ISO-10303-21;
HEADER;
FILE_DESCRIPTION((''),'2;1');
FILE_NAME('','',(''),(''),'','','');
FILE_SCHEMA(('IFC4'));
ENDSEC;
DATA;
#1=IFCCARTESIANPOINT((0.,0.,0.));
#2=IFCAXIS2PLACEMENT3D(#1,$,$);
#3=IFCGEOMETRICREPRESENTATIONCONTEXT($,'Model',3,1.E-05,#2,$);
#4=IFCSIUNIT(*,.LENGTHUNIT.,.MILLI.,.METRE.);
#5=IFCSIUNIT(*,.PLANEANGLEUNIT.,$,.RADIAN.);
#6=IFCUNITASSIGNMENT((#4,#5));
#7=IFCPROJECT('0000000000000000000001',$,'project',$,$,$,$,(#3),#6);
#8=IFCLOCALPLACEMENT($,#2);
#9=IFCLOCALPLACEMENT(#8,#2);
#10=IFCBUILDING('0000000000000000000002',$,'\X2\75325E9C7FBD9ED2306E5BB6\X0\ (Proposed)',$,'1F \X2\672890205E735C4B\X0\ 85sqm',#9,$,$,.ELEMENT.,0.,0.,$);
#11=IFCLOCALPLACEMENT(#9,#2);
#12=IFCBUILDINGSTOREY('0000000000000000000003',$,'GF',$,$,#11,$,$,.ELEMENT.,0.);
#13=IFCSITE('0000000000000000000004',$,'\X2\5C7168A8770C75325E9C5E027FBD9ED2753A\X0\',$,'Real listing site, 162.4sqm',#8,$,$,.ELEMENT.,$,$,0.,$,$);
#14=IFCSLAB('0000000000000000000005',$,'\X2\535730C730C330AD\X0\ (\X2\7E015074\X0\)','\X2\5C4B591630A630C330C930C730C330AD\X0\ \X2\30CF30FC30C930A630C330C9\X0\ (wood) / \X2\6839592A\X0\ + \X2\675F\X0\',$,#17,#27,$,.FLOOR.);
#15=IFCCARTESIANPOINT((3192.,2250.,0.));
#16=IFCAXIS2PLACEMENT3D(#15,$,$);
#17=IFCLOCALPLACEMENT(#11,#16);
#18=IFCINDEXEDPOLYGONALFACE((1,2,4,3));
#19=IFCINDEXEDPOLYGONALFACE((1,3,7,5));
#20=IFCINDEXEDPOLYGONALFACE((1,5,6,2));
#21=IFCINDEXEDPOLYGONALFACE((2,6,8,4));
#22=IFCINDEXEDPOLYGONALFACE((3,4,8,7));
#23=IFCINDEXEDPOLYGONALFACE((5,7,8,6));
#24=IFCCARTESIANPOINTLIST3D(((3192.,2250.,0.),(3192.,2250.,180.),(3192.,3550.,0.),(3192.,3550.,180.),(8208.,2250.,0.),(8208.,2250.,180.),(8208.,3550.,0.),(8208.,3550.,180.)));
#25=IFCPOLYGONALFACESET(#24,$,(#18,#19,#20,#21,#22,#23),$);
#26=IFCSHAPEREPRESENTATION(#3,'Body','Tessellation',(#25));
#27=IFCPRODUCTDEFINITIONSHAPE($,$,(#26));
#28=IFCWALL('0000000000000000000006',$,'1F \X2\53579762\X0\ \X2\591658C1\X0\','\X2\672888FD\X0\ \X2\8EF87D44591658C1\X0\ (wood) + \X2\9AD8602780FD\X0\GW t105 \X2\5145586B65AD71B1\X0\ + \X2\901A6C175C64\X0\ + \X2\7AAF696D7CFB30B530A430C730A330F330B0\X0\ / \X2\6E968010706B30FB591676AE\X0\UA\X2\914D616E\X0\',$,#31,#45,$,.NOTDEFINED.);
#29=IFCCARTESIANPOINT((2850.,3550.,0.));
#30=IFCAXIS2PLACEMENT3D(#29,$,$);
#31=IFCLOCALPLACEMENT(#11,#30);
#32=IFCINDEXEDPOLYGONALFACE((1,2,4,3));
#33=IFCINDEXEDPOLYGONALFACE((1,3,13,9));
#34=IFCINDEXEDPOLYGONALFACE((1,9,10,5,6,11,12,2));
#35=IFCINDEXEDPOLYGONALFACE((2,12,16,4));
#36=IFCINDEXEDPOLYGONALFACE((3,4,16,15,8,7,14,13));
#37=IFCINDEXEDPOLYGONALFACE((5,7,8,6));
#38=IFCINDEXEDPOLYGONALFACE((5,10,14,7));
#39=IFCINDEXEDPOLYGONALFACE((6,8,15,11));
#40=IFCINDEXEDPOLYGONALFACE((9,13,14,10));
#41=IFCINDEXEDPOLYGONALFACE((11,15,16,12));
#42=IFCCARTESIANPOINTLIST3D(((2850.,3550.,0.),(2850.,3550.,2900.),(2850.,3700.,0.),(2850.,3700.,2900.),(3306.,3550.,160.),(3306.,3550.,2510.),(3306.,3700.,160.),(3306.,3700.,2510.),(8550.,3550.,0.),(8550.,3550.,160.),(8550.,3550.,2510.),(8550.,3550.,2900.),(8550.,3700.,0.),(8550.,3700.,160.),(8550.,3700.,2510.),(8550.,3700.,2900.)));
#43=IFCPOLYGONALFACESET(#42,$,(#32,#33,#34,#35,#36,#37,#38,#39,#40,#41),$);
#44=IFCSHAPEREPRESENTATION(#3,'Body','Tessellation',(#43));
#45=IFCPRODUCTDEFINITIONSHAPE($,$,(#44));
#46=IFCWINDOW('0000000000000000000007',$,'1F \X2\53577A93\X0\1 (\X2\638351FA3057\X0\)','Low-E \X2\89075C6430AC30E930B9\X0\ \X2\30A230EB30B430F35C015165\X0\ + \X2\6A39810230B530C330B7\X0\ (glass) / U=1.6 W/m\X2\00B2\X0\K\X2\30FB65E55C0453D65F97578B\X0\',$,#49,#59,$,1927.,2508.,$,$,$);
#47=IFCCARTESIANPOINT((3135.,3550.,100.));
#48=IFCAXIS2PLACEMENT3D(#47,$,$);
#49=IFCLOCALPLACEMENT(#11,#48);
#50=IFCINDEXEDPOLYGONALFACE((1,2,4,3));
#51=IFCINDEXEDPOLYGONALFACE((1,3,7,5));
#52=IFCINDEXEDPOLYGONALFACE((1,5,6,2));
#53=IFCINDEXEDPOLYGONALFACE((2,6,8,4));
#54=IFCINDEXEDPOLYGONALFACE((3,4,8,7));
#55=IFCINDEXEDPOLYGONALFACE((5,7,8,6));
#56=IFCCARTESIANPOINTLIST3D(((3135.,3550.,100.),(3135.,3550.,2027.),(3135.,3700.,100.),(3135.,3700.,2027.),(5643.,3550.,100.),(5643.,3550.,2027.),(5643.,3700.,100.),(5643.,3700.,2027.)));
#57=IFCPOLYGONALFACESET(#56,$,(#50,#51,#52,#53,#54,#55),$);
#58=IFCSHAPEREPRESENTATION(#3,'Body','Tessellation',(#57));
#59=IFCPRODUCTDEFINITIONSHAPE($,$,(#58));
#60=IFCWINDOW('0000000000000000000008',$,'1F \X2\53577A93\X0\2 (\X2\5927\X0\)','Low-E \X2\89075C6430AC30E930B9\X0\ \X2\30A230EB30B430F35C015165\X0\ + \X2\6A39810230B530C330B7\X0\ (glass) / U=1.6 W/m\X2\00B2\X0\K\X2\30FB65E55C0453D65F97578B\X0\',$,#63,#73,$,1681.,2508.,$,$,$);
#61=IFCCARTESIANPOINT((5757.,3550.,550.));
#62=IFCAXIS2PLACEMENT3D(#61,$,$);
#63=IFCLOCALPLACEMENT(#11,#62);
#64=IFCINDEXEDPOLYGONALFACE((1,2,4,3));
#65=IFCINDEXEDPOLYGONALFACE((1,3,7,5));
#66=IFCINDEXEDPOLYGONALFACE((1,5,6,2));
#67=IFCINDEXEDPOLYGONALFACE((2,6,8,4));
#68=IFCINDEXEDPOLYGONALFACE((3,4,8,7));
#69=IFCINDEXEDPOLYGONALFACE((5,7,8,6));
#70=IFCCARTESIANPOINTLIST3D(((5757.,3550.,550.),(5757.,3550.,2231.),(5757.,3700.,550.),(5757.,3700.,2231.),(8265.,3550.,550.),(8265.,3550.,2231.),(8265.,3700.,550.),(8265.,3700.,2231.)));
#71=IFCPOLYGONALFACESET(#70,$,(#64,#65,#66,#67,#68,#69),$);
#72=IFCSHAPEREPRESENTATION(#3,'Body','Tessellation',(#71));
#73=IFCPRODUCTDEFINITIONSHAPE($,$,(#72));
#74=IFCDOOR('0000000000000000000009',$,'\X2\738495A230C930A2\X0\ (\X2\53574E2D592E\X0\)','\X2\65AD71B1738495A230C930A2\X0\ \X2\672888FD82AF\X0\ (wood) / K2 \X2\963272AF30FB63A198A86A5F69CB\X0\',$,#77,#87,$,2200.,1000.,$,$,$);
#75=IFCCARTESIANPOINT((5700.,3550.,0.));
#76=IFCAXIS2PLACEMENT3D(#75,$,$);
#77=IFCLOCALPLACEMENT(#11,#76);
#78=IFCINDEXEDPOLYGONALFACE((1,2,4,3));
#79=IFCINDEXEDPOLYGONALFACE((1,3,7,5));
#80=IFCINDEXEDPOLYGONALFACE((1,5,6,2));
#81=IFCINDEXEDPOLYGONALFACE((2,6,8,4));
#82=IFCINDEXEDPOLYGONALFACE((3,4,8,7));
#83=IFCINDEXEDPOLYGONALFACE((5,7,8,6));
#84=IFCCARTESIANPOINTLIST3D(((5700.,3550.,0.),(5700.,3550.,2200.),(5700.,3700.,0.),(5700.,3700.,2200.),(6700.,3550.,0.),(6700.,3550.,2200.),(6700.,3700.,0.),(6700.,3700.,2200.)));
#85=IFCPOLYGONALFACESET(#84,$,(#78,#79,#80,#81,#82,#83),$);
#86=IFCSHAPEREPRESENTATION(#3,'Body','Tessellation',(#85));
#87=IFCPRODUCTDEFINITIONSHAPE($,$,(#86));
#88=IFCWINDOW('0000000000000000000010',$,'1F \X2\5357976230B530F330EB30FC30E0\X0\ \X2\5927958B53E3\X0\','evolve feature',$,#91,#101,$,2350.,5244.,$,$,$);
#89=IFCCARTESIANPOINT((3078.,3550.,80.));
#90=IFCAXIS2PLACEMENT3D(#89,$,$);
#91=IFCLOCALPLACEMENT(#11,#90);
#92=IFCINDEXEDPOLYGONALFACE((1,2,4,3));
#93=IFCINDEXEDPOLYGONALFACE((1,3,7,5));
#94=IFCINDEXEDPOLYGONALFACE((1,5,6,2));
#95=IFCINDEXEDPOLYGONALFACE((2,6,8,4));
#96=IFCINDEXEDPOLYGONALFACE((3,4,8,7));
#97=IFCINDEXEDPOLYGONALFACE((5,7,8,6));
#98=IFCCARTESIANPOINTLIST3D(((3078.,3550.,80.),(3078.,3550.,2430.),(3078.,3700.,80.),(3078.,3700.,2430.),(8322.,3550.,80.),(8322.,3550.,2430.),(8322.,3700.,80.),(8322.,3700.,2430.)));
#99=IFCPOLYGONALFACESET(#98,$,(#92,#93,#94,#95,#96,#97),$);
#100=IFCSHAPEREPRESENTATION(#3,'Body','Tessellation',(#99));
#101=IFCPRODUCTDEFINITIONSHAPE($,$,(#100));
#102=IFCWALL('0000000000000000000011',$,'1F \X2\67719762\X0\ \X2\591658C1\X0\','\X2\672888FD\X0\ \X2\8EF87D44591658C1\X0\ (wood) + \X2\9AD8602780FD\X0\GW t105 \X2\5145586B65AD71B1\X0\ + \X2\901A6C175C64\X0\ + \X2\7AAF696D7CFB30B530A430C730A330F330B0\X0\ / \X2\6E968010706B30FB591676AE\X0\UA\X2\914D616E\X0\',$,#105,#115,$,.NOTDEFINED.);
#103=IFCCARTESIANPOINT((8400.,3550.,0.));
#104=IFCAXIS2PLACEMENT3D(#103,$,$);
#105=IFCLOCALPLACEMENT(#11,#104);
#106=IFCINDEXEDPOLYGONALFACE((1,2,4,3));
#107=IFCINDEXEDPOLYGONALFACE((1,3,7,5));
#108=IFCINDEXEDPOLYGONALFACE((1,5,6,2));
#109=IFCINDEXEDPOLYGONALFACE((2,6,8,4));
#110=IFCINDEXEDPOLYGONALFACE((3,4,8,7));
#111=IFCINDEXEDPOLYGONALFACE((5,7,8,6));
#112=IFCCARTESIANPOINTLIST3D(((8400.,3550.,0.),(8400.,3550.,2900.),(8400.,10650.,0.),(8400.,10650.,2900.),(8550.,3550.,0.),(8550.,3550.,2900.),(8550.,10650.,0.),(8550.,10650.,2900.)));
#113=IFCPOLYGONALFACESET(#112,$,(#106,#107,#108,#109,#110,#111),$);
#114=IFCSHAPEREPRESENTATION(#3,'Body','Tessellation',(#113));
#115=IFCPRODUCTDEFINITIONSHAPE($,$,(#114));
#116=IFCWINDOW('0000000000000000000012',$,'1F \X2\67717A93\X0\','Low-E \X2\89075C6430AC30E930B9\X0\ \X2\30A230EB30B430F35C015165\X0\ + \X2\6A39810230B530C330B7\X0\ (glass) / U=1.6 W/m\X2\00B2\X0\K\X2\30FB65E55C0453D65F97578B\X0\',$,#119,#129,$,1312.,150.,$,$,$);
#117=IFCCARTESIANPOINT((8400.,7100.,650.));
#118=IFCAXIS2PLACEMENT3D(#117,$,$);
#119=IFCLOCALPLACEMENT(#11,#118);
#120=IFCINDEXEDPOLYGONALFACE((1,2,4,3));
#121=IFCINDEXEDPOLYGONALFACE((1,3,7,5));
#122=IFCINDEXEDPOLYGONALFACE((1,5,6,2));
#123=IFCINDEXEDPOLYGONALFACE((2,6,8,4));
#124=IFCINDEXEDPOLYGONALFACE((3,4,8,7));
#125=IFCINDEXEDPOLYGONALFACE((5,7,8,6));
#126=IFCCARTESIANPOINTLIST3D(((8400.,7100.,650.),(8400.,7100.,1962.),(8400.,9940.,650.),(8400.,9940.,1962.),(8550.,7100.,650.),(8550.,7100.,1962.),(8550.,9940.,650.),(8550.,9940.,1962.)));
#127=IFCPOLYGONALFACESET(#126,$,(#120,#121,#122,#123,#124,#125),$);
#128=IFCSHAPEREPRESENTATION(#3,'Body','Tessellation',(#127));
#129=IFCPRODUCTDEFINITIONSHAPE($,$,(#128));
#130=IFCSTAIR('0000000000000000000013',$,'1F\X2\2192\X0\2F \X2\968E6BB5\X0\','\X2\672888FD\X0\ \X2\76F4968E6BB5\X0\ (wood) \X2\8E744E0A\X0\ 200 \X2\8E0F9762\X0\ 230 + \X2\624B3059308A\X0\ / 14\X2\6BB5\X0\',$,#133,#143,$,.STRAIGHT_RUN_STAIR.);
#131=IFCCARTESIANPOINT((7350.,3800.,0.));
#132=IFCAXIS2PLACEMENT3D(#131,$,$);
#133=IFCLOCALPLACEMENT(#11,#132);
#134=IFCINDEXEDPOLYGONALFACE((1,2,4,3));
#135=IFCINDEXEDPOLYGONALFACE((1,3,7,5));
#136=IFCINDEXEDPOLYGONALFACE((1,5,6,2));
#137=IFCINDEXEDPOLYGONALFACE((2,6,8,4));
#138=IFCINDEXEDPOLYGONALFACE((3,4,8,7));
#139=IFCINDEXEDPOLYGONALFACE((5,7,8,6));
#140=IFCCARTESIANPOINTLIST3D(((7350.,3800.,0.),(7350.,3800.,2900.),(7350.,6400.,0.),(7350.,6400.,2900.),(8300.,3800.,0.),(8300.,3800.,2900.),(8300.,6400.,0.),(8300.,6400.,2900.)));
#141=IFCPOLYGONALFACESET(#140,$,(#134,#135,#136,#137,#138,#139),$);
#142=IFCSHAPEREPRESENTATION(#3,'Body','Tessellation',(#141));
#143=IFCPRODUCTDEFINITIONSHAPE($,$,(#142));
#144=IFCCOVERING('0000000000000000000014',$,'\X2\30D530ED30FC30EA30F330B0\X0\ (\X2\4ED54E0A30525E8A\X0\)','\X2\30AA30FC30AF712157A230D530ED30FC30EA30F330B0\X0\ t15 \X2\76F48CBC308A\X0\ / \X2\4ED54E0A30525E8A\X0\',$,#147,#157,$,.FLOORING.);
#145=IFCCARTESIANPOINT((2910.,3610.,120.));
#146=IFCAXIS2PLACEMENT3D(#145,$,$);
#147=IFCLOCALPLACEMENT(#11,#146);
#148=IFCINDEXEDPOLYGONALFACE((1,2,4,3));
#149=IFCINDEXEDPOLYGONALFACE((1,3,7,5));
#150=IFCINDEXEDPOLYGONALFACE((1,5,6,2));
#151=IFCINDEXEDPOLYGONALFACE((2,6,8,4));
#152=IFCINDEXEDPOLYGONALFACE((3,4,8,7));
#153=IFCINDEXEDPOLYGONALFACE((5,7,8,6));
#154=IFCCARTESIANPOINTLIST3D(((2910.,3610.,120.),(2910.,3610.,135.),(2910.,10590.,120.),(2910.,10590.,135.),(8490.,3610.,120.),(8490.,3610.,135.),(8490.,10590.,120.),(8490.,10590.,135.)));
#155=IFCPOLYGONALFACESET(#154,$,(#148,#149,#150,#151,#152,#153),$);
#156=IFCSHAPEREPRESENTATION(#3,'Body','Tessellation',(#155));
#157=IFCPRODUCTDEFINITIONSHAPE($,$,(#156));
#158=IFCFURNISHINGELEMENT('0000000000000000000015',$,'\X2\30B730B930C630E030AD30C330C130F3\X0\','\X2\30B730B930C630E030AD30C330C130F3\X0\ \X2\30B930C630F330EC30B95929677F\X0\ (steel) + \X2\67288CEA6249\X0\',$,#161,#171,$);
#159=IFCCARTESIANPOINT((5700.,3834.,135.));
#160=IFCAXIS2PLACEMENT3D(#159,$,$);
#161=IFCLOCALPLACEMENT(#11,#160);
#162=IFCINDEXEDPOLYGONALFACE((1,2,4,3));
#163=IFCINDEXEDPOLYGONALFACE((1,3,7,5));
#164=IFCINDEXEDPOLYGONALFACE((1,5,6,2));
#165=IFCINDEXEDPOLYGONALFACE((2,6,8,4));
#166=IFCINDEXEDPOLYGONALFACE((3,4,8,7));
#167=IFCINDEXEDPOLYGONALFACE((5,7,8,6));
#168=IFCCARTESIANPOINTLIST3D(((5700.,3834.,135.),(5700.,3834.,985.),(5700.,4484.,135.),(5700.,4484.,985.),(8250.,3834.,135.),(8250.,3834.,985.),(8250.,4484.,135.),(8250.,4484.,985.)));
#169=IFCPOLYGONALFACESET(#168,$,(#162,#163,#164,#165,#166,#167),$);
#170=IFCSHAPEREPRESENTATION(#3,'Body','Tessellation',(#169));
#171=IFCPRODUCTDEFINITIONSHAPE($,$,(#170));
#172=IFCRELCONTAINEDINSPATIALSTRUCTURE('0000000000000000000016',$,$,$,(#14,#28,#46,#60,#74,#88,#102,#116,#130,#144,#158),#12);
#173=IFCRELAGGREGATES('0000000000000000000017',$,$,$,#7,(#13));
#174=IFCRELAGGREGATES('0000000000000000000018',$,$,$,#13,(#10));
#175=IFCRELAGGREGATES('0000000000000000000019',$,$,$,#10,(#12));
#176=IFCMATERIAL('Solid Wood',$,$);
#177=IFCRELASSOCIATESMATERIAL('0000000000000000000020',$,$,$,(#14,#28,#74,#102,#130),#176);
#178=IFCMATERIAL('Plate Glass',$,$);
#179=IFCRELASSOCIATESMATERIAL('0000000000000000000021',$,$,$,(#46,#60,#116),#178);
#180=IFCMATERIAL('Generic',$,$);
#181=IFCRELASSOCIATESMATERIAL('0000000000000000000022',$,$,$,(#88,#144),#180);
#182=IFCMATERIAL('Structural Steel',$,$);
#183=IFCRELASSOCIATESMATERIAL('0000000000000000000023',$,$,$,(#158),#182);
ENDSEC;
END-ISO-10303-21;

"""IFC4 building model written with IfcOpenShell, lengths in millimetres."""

from ifc_helpers import new_model, si_unit, frame, frame_2d, origin, place, context, project, spatial, rectangle, extrude, material, element, fill, save


model = new_model("IFC4")

# Units and contexts
model_context = context("Model", 3, precision=1e-05, world=origin())
ifc_project = project(units=[si_unit("LENGTHUNIT", "METRE", prefix="MILLI"), si_unit("PLANEANGLEUNIT", "RADIAN")], contexts=[model_context])

# Site, building, storey
site_placement = place(None, origin())
site = spatial("IfcSite", under=ifc_project, at=site_placement, Name="山梨県甲府市羽黒町", ObjectType="Real listing site, 162.4sqm", CompositionType="ELEMENT", RefElevation=0.0)
building_placement = place(site_placement, origin())
building = spatial("IfcBuilding", under=site, at=building_placement, Name="甲府羽黒の家 (Proposed)", ObjectType="1F 木造平屋 85sqm", CompositionType="ELEMENT", ElevationOfRefHeight=0.0, ElevationOfTerrain=0.0)
storey_placement = place(building_placement, origin())
storey = spatial("IfcBuildingStorey", under=building, at=storey_placement, Name="GF", CompositionType="ELEMENT", Elevation=0.0)

# Slab
ifc_material_1 = material(Name="Solid Wood")
slab_1_placement = place(storey_placement, frame((3192.0, 2250.0, 0.0)))
element("IfcSlab", 1, at=slab_1_placement, inside=storey, material=ifc_material_1, Name="南デッキ (縁側)", Description="屋外ウッドデッキ ハードウッド (wood) / 根太 + 束", PredefinedType="FLOOR", context=model_context, shape_type="SweptSolid", body=[
    extrude(rectangle(XDim=5016.0, YDim=1300.0, at=frame_2d((2508.0, 650.0))), frame((3192.0, 2250.0, 0.0)), (0.0, 0.0, 1.0), 180.0),
])
ifc_material_2 = material(Name="Generic")

# Wall, openings, windows, door
wall_1_placement = place(storey_placement, frame((2850.0, 3550.0, 0.0)))
wall_1 = element("IfcWall", 2, at=wall_1_placement, inside=storey, material=ifc_material_1, Name="1F 南面 外壁", Description="木製 軸組外壁 (wood) + 高性能GW t105 充填断熱 + 通気層 + 窯業系サイディング / 準耐火・外皮UA配慮", PredefinedType="NOTDEFINED", context=model_context, shape_type="SweptSolid", body=[
    extrude(rectangle(XDim=5700.0, YDim=150.0, at=frame_2d((2850.0, 75.0))), frame((2850.0, 3550.0, 0.0)), (0.0, 0.0, 1.0), 2900.0),
])
opening_1_placement = place(storey_placement, frame((3135.0, 3550.0, 100.0)))
opening_1 = element("IfcOpeningElement", 3, at=opening_1_placement, cuts=wall_1, PredefinedType="NOTDEFINED", context=model_context, shape_type="SweptSolid", body=[
    extrude(rectangle(XDim=2508.0, YDim=150.0, at=frame_2d((1254.0, 75.0))), frame((3135.0, 3550.0, 100.0)), (0.0, 0.0, 1.0), 1927.0),
])
opening_2_placement = place(storey_placement, frame((5757.0, 3550.0, 550.0)))
opening_2 = element("IfcOpeningElement", 4, at=opening_2_placement, cuts=wall_1, PredefinedType="NOTDEFINED", context=model_context, shape_type="SweptSolid", body=[
    extrude(rectangle(XDim=2508.0, YDim=150.0, at=frame_2d((1254.0, 75.0))), frame((5757.0, 3550.0, 550.0)), (0.0, 0.0, 1.0), 1681.0),
])
opening_3_placement = place(storey_placement, frame((5700.0, 3550.0, 0.0)))
opening_3 = element("IfcOpeningElement", 5, at=opening_3_placement, cuts=wall_1, PredefinedType="NOTDEFINED", context=model_context, shape_type="SweptSolid", body=[
    extrude(rectangle(XDim=1000.0, YDim=150.0, at=frame_2d((500.0, 75.0))), frame((5700.0, 3550.0, 0.0)), (0.0, 0.0, 1.0), 2200.0),
])
opening_4_placement = place(storey_placement, frame((3078.0, 3550.0, 80.0)))
opening_4 = element("IfcOpeningElement", 6, at=opening_4_placement, cuts=wall_1, PredefinedType="NOTDEFINED", context=model_context, shape_type="SweptSolid", body=[
    extrude(rectangle(XDim=5244.0, YDim=150.0, at=frame_2d((2622.0, 75.0))), frame((3078.0, 3550.0, 80.0)), (0.0, 0.0, 1.0), 2350.0),
])
ifc_material_3 = material(Name="Plate Glass")
window_1_placement = place(storey_placement, frame((3135.0, 3550.0, 100.0)))
window_1 = element("IfcWindow", 7, at=window_1_placement, inside=storey, material=ifc_material_3, Name="1F 南窓1 (掃出し)", Description="Low-E 複層ガラス アルゴン封入 + 樹脂サッシ (glass) / U=1.6 W/m²K・日射取得型", OverallHeight=1927.0, OverallWidth=2508.0, context=model_context, shape_type="SweptSolid", body=[
    extrude(rectangle(XDim=2508.0, YDim=150.0, at=frame_2d((1254.0, 75.0))), frame((3135.0, 3550.0, 100.0)), (0.0, 0.0, 1.0), 1927.0),
])
fill(opening_1, window_1)
window_2_placement = place(storey_placement, frame((5757.0, 3550.0, 550.0)))
window_2 = element("IfcWindow", 8, at=window_2_placement, inside=storey, material=ifc_material_3, Name="1F 南窓2 (大)", Description="Low-E 複層ガラス アルゴン封入 + 樹脂サッシ (glass) / U=1.6 W/m²K・日射取得型", OverallHeight=1681.0, OverallWidth=2508.0, context=model_context, shape_type="SweptSolid", body=[
    extrude(rectangle(XDim=2508.0, YDim=150.0, at=frame_2d((1254.0, 75.0))), frame((5757.0, 3550.0, 550.0)), (0.0, 0.0, 1.0), 1681.0),
])
fill(opening_2, window_2)
door_placement = place(storey_placement, frame((5700.0, 3550.0, 0.0)))
door = element("IfcDoor", 9, at=door_placement, inside=storey, material=ifc_material_1, Name="玄関ドア (南中央)", Description="断熱玄関ドア 木製芯 (wood) / K2 防犯・採風機構", OverallHeight=2200.0, OverallWidth=1000.0, context=model_context, shape_type="SweptSolid", body=[
    extrude(rectangle(XDim=1000.0, YDim=150.0, at=frame_2d((500.0, 75.0))), frame((5700.0, 3550.0, 0.0)), (0.0, 0.0, 1.0), 2200.0),
])
fill(opening_3, door)
window_3_placement = place(storey_placement, frame((3078.0, 3550.0, 80.0)))
window_3 = element("IfcWindow", 10, at=window_3_placement, inside=storey, material=ifc_material_2, Name="1F 南面サンルーム 大開口", Description="evolve feature", OverallHeight=2350.0, OverallWidth=5244.0, context=model_context, shape_type="SweptSolid", body=[
    extrude(rectangle(XDim=5244.0, YDim=150.0, at=frame_2d((2622.0, 75.0))), frame((3078.0, 3550.0, 80.0)), (0.0, 0.0, 1.0), 2350.0),
])
fill(opening_4, window_3)

# Wall, opening, window
wall_2_placement = place(storey_placement, frame((8400.0, 3550.0, 0.0)))
wall_2 = element("IfcWall", 11, at=wall_2_placement, inside=storey, material=ifc_material_1, Name="1F 東面 外壁", Description="木製 軸組外壁 (wood) + 高性能GW t105 充填断熱 + 通気層 + 窯業系サイディング / 準耐火・外皮UA配慮", PredefinedType="NOTDEFINED", context=model_context, shape_type="SweptSolid", body=[
    extrude(rectangle(XDim=150.0, YDim=7100.0, at=frame_2d((75.0, 3550.0))), frame((8400.0, 3550.0, 0.0)), (0.0, 0.0, 1.0), 2900.0),
])
opening_5_placement = place(storey_placement, frame((8400.0, 7100.0, 650.0)))
opening_5 = element("IfcOpeningElement", 12, at=opening_5_placement, cuts=wall_2, PredefinedType="NOTDEFINED", context=model_context, shape_type="SweptSolid", body=[
    extrude(rectangle(XDim=150.0, YDim=2840.0, at=frame_2d((75.0, 1420.0))), frame((8400.0, 7100.0, 650.0)), (0.0, 0.0, 1.0), 1312.0),
])
window_4_placement = place(storey_placement, frame((8400.0, 7100.0, 650.0)))
window_4 = element("IfcWindow", 13, at=window_4_placement, inside=storey, material=ifc_material_3, Name="1F 東窓", Description="Low-E 複層ガラス アルゴン封入 + 樹脂サッシ (glass) / U=1.6 W/m²K・日射取得型", OverallHeight=1312.0, OverallWidth=150.0, context=model_context, shape_type="SweptSolid", body=[
    extrude(rectangle(XDim=150.0, YDim=2840.0, at=frame_2d((75.0, 1420.0))), frame((8400.0, 7100.0, 650.0)), (0.0, 0.0, 1.0), 1312.0),
])
fill(opening_5, window_4)

# Stair
stair_placement = place(storey_placement, frame((7350.0, 3800.0, 0.0)))
element("IfcStair", 14, at=stair_placement, inside=storey, material=ifc_material_1, Name="1F→2F 階段", Description="木製 直階段 (wood) 蹴上 200 踏面 230 + 手すり / 14段", PredefinedType="STRAIGHT_RUN_STAIR", context=model_context, shape_type="SweptSolid", body=[
    extrude(rectangle(XDim=950.0, YDim=2600.0, at=frame_2d((475.0, 1300.0))), frame((7350.0, 3800.0, 0.0)), (0.0, 0.0, 1.0), 2900.0),
])

# Covering
covering_placement = place(storey_placement, frame((2910.0, 3610.0, 120.0)))
element("IfcCovering", 15, at=covering_placement, inside=storey, material=ifc_material_2, Name="フローリング (仕上げ床)", Description="オーク無垢フローリング t15 直貼り / 仕上げ床", PredefinedType="FLOORING", context=model_context, shape_type="SweptSolid", body=[
    extrude(rectangle(XDim=5580.0, YDim=6980.0, at=frame_2d((2790.0, 3490.0))), frame((2910.0, 3610.0, 120.0)), (0.0, 0.0, 1.0), 15.0),
])

# Furnishing element
ifc_material_4 = material(Name="Structural Steel")
furnishing_placement = place(storey_placement, frame((5700.0, 3834.0, 135.0)))
element("IfcFurnishingElement", 16, at=furnishing_placement, inside=storey, material=ifc_material_4, Name="システムキッチン", Description="システムキッチン ステンレス天板 (steel) + 木質扉", context=model_context, shape_type="SweptSolid", body=[
    extrude(rectangle(XDim=2550.0, YDim=650.0, at=frame_2d((1275.0, 325.0))), frame((5700.0, 3834.0, 135.0)), (0.0, 0.0, 1.0), 850.0),
])

save(model, "model.ifc")
